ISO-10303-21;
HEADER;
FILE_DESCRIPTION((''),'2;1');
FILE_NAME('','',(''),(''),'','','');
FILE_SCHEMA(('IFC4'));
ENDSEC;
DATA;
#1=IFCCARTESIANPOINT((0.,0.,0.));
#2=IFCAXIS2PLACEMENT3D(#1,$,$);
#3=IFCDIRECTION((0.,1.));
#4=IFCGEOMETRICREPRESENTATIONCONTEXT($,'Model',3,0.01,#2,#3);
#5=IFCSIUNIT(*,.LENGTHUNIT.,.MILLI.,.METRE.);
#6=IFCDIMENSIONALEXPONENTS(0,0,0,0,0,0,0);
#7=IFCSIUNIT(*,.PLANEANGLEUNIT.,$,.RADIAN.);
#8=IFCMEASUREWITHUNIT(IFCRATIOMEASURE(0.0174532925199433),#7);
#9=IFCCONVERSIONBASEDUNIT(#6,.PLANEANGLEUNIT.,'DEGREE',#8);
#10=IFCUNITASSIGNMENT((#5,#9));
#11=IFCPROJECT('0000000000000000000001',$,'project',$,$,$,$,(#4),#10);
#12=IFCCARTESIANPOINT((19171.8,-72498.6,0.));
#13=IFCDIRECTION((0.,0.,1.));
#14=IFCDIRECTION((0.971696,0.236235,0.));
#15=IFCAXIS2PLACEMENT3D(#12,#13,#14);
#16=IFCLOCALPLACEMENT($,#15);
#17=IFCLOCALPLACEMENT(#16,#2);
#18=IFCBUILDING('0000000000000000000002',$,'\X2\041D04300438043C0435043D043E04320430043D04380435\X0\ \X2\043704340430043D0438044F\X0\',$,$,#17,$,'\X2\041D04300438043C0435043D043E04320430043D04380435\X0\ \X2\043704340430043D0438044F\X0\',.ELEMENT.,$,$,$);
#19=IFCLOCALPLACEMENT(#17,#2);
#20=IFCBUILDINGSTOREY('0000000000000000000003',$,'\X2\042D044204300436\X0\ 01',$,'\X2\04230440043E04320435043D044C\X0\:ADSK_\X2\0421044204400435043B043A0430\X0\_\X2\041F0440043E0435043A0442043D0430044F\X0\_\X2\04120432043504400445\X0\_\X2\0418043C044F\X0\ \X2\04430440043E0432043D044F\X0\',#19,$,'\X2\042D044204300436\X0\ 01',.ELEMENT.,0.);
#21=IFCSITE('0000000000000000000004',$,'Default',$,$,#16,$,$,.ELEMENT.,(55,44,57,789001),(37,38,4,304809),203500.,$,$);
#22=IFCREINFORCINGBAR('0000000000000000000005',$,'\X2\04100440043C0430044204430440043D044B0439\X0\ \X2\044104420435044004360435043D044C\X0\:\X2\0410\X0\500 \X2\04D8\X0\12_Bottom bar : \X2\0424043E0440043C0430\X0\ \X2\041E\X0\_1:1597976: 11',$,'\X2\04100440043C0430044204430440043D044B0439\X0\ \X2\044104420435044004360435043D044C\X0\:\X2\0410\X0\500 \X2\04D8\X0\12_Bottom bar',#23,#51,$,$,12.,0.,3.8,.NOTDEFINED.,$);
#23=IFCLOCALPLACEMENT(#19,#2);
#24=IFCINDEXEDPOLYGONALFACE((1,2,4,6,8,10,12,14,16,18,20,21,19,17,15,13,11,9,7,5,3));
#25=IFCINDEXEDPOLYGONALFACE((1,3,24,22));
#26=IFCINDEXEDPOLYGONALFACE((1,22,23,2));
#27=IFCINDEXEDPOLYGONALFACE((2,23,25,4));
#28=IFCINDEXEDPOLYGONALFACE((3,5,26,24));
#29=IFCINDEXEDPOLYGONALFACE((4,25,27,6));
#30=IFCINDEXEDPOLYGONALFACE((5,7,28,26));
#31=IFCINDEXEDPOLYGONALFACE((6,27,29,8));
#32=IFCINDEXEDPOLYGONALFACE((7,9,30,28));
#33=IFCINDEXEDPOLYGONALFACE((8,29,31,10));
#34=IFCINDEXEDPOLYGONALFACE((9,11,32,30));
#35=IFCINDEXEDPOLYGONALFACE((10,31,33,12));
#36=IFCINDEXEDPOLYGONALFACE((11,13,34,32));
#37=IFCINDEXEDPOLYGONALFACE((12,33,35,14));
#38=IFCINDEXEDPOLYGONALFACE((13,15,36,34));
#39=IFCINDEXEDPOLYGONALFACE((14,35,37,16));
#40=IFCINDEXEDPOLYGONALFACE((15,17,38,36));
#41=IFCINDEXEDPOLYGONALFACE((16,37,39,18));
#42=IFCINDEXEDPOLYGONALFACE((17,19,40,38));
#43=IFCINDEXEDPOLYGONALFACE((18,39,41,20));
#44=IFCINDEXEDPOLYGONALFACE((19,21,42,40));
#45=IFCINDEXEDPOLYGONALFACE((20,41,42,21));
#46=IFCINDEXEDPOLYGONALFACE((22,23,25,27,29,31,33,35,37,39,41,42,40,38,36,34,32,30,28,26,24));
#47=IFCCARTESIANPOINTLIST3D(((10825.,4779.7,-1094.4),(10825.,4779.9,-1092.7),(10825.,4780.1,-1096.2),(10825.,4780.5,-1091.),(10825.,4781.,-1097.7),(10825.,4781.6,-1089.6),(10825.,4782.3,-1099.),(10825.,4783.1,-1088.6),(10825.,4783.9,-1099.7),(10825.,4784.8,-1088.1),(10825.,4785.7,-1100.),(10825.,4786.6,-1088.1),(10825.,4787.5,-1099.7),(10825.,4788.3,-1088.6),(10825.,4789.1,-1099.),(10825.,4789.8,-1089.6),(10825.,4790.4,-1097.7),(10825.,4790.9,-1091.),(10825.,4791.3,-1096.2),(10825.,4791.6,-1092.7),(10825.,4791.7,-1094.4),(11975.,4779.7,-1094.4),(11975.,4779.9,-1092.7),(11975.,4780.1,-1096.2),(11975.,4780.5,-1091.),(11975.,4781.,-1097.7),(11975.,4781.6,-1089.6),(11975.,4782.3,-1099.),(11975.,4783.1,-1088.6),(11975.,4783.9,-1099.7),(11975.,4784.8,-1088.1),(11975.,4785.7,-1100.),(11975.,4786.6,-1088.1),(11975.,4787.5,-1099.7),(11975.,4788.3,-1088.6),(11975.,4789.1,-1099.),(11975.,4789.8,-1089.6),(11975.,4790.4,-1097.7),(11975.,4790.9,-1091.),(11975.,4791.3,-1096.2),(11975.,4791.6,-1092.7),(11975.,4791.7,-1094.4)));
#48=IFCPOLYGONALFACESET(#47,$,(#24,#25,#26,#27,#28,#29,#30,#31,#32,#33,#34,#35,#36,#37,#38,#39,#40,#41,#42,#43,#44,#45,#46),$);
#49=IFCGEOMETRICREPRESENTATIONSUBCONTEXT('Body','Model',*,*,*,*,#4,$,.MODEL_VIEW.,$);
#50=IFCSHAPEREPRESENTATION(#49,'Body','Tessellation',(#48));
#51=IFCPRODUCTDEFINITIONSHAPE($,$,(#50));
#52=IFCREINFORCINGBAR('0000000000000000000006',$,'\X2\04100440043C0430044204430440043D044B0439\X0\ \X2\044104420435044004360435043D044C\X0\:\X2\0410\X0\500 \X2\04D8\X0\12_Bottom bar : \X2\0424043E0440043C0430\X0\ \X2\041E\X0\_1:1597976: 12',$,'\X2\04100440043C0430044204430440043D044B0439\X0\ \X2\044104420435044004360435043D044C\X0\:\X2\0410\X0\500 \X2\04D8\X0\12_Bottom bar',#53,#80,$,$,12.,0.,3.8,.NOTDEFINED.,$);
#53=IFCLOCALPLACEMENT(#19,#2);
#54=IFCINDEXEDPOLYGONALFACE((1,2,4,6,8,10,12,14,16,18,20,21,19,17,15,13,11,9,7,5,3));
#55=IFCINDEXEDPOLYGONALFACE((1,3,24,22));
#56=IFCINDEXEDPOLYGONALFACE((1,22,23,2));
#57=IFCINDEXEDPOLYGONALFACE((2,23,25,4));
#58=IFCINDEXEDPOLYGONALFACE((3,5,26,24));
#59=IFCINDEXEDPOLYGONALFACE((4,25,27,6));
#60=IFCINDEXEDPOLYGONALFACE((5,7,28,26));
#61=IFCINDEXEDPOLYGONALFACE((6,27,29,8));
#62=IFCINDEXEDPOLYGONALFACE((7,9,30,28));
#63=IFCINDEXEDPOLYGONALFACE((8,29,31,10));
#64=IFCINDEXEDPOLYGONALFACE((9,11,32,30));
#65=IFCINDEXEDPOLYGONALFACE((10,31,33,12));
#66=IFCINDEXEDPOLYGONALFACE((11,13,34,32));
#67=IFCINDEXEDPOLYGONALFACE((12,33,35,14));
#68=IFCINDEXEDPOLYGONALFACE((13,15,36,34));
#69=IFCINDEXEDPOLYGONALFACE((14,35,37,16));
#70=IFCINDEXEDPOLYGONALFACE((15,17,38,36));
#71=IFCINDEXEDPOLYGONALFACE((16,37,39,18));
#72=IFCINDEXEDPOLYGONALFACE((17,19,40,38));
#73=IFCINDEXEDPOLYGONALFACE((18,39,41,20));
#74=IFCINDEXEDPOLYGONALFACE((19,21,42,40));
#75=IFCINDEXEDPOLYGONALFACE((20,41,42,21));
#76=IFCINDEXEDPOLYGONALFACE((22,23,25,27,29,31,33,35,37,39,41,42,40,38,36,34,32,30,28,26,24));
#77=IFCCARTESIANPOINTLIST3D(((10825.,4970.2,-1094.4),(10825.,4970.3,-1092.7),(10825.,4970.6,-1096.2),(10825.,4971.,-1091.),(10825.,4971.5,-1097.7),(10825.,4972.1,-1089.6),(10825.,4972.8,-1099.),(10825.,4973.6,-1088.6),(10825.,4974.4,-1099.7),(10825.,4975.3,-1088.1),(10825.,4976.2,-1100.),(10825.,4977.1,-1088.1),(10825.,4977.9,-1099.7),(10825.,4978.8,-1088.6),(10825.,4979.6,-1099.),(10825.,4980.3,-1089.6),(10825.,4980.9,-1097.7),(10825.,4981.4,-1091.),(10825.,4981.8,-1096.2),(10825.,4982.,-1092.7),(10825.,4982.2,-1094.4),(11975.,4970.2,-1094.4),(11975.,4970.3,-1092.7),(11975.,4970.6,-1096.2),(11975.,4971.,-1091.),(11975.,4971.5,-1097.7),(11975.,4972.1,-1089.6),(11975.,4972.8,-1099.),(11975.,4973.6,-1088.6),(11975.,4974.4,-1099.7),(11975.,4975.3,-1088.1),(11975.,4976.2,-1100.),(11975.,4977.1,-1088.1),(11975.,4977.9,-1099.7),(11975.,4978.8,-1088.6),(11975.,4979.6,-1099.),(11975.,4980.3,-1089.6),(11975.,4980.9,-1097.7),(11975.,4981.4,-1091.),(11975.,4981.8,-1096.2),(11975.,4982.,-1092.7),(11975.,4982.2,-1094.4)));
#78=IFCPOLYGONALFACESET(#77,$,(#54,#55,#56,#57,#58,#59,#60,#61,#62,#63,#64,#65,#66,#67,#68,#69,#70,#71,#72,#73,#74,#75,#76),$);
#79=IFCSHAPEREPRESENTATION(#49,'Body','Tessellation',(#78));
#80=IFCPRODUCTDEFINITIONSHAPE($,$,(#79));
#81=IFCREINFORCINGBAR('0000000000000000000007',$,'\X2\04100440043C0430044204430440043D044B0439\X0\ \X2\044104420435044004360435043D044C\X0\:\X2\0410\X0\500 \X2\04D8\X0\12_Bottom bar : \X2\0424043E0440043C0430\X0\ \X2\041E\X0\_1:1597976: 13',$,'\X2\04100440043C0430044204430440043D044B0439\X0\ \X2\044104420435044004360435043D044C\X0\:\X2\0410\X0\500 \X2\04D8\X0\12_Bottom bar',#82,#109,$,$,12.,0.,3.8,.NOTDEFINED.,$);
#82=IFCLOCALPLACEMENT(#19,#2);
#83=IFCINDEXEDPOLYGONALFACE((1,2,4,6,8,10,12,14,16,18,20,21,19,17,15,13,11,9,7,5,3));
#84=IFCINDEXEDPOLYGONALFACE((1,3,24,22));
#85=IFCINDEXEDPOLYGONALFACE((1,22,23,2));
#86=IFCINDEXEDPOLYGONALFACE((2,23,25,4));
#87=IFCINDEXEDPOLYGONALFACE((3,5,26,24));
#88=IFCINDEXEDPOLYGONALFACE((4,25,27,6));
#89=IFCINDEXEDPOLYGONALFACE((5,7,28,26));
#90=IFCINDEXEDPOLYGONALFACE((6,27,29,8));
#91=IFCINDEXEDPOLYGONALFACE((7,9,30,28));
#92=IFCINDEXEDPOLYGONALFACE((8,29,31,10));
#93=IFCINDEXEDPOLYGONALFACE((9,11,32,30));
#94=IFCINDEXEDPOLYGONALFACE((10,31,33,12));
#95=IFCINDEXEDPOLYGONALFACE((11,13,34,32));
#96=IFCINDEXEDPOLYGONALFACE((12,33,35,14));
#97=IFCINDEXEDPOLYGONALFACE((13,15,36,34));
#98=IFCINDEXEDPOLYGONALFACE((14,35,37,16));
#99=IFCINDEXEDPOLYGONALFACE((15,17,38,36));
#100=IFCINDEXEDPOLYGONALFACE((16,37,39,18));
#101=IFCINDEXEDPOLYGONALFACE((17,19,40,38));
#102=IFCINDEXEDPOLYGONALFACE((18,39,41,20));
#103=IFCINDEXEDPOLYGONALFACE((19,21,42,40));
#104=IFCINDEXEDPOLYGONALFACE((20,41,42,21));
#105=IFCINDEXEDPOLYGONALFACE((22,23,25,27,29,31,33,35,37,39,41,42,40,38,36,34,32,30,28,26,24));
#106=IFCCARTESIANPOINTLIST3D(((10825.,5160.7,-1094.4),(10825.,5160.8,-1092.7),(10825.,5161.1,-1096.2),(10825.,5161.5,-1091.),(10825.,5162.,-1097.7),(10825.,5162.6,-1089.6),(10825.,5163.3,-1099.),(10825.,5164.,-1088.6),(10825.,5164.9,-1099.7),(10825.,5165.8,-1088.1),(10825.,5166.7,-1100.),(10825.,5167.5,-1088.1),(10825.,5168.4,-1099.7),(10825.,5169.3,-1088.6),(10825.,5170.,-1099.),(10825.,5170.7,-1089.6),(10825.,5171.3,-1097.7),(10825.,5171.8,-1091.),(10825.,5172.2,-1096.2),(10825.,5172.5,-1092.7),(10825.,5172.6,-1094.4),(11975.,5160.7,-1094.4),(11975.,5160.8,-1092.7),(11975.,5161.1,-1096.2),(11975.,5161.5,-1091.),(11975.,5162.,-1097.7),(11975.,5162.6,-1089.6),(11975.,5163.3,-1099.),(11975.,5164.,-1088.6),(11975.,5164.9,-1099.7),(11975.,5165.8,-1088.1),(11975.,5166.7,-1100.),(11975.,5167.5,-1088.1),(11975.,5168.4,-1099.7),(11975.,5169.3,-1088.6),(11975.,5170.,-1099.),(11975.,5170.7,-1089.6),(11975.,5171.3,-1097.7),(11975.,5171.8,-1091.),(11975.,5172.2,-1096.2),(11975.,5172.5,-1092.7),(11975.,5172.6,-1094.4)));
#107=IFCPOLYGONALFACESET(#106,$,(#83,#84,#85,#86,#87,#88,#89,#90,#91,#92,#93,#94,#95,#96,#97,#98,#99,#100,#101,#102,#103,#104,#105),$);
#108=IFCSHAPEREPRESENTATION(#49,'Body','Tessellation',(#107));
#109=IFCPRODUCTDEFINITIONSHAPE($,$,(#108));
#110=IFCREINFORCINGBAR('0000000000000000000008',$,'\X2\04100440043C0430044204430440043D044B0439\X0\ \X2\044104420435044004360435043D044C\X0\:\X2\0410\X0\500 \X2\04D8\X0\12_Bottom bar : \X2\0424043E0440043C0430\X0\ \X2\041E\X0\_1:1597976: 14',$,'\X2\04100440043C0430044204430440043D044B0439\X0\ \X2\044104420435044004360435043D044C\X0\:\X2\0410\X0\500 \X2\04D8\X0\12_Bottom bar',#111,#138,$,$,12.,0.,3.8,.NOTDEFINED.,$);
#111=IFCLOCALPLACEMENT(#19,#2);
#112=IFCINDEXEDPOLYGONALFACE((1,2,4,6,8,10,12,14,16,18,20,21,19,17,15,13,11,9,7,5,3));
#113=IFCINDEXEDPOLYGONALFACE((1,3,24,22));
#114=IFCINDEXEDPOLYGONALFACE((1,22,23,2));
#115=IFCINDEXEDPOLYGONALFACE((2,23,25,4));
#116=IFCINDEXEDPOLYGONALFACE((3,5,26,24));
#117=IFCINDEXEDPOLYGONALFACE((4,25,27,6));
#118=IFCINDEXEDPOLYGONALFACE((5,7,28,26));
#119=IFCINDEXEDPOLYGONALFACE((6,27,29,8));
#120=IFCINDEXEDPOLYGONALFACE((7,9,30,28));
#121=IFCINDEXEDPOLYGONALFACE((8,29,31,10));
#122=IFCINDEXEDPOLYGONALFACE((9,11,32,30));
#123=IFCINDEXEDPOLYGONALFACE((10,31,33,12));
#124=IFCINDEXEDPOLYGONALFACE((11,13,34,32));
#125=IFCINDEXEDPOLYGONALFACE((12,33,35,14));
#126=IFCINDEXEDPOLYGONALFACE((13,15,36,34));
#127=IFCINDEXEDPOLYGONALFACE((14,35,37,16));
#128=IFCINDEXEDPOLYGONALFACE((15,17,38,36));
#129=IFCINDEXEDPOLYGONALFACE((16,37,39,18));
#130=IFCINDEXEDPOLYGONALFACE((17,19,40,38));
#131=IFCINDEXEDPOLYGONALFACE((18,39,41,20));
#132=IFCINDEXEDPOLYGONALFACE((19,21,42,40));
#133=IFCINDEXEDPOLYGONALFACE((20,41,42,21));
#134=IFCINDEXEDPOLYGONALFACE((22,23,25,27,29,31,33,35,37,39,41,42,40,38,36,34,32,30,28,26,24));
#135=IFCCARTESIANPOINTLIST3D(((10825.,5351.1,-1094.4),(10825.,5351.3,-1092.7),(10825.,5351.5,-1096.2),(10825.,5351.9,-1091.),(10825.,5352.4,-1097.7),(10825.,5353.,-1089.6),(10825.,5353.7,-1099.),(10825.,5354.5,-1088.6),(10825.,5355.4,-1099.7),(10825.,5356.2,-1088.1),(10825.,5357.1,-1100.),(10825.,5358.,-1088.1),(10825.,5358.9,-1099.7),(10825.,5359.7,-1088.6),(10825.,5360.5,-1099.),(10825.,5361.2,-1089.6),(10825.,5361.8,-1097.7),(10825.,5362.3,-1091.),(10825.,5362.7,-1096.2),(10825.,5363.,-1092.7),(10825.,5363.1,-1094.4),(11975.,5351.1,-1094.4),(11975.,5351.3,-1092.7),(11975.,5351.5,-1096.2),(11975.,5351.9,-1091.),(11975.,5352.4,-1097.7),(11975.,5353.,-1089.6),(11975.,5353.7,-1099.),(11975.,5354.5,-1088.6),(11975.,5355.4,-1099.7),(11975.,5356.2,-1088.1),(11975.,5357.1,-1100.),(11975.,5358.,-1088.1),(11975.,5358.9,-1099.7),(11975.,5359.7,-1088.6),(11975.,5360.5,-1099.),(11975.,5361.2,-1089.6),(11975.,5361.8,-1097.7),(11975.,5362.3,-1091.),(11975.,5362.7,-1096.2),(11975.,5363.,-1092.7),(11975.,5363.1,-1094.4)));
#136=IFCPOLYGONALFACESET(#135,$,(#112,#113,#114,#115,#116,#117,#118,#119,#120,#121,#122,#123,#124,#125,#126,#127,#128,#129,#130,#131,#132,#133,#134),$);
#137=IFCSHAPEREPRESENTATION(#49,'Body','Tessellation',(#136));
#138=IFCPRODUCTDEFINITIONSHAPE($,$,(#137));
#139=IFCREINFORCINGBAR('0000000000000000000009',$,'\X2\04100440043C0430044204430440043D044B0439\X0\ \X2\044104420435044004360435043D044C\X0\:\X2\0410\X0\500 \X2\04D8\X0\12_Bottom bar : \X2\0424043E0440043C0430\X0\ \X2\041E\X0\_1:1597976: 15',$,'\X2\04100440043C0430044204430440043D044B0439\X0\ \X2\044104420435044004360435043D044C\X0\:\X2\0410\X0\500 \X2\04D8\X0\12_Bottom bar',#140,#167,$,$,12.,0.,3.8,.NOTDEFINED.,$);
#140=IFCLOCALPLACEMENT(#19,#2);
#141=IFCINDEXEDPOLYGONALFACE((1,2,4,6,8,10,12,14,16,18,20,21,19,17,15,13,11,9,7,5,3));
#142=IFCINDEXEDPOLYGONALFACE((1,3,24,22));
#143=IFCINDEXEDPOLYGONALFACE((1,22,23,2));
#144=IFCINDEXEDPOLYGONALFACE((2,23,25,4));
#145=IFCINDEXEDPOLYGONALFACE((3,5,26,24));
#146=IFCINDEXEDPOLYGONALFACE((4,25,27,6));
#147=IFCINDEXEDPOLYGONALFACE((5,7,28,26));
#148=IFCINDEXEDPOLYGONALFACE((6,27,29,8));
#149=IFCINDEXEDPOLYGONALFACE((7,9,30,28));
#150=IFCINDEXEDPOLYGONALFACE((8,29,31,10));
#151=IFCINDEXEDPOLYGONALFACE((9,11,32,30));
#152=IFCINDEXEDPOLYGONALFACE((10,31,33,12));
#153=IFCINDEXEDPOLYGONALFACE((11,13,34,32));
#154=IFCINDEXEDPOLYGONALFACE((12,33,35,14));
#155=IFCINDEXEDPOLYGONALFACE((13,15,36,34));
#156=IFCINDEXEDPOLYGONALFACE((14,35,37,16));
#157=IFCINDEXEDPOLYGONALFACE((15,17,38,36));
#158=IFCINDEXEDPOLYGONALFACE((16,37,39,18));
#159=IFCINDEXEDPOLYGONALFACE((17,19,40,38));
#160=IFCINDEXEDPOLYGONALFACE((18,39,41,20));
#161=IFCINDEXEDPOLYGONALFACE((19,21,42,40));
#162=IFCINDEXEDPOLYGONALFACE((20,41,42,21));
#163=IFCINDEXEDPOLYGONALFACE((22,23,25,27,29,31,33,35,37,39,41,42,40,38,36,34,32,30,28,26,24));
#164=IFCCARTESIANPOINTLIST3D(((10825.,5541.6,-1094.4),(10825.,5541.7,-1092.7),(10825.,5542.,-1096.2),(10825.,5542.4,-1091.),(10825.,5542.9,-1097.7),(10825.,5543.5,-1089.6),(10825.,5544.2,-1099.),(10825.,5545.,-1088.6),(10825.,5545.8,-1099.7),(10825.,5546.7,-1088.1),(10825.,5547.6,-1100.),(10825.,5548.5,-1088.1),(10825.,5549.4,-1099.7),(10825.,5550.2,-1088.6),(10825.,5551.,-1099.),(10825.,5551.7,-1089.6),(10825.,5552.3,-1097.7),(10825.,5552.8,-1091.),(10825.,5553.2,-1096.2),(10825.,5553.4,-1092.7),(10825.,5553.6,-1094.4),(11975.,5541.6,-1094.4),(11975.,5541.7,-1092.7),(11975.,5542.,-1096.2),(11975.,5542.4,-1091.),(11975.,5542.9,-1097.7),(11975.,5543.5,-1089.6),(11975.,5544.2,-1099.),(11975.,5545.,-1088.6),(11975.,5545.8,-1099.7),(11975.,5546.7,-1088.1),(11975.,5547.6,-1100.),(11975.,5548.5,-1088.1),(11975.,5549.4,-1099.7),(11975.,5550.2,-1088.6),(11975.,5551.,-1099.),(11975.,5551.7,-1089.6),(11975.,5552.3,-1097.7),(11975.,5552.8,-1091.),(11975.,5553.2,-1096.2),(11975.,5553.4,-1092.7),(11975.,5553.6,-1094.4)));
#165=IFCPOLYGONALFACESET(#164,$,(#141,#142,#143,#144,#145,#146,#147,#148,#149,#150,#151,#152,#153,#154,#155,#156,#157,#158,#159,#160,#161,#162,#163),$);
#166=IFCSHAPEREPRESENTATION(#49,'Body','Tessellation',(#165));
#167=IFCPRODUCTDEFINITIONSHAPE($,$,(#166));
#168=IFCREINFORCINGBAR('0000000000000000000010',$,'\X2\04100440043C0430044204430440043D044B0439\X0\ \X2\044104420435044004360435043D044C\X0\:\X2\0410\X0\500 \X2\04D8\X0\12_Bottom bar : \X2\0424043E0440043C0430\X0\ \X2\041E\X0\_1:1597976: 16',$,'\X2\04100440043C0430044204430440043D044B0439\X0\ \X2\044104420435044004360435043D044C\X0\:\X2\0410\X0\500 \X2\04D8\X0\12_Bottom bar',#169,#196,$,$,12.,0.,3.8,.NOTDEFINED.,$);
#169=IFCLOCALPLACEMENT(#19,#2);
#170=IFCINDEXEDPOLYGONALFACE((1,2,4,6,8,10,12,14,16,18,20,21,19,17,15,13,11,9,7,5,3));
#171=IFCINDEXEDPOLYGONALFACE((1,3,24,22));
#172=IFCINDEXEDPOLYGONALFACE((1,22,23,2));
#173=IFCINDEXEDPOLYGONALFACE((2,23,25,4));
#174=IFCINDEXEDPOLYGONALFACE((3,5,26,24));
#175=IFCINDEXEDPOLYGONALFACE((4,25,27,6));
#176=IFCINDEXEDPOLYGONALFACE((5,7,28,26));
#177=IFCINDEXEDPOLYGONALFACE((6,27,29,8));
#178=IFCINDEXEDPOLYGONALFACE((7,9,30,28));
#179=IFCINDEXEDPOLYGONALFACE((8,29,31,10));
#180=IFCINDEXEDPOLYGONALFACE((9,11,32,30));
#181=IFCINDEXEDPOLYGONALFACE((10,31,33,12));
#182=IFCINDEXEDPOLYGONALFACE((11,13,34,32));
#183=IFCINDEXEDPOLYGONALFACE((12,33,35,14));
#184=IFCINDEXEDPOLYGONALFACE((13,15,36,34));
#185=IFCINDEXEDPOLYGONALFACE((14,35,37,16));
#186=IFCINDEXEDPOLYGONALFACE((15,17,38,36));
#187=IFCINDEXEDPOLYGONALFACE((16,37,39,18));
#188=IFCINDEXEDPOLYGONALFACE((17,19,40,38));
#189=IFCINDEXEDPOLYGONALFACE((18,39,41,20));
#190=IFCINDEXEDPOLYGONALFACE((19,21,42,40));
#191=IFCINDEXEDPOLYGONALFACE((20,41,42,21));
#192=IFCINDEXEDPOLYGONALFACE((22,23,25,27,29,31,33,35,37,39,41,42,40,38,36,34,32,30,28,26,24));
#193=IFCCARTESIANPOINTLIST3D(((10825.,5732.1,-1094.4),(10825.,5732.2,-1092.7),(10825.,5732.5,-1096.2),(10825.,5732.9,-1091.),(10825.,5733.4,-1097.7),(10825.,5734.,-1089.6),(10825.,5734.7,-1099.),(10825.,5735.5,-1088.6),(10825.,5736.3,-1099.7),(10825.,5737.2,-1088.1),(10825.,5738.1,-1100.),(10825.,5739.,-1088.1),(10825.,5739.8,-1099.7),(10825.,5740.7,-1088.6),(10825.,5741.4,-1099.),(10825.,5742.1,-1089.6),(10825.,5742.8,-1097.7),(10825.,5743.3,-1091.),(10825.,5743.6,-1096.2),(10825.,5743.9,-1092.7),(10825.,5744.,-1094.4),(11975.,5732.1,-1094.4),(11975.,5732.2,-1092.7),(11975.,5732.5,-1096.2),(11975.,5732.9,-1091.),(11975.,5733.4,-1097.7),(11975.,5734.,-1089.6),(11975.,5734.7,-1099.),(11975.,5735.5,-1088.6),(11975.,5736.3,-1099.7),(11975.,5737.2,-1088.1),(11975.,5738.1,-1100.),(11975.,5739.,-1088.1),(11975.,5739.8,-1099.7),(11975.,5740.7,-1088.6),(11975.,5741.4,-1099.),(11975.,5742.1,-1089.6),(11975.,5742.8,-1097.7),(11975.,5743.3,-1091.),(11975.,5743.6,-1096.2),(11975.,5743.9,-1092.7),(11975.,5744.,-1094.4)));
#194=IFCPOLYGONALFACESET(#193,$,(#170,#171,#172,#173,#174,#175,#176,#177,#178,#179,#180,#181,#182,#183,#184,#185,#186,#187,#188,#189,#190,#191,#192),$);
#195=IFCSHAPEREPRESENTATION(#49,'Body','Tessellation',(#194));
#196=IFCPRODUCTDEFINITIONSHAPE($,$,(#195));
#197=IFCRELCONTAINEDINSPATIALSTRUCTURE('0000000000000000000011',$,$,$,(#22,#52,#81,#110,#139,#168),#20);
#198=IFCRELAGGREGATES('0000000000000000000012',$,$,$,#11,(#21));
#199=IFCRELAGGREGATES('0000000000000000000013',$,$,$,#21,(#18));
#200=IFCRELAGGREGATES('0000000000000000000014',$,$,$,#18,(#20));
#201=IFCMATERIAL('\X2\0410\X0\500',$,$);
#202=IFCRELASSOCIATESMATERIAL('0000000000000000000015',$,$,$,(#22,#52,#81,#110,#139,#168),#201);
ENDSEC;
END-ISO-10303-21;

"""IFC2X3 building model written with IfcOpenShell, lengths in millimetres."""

from ifc_helpers import new_model, entity, si_unit, converted_unit, direction, frame, origin, place, context, subcontext, project, spatial, material, element, save


model = new_model("IFC2X3")

# Units and contexts
model_context = context("Model", 3, precision=0.01, world=origin(), true_north=direction((0.0, 1.0)))
body_context = subcontext(model_context, "Body", "Model", "MODEL_VIEW")
ifc_project = project(units=[si_unit("LENGTHUNIT", "METRE", prefix="MILLI"), converted_unit("PLANEANGLEUNIT", "DEGREE", entity("IfcRatioMeasure", 0.0174532925199433), si_unit("PLANEANGLEUNIT", "RADIAN"), dimensions=[0, 0, 0, 0, 0, 0, 0])], contexts=[model_context])

# Site, building, storey
site_placement = place(None, frame((19171.8, -72498.6, 0.0), z_axis=(0.0, 0.0, 1.0), x_axis=(0.971696, 0.236235, 0.0)))
site = spatial("IfcSite", under=ifc_project, at=site_placement, Name="Default", CompositionType="ELEMENT", RefLatitude=(55, 44, 57, 789001), RefLongitude=(37, 38, 4, 304809), RefElevation=203500.0)
building_placement = place(site_placement, origin())
building = spatial("IfcBuilding", under=site, at=building_placement, Name="Наименование здания", LongName="Наименование здания", CompositionType="ELEMENT")
storey_placement = place(building_placement, origin())
storey = spatial("IfcBuildingStorey", under=building, at=storey_placement, Name="Этаж 01", ObjectType="Уровень:ADSK_Стрелка_Проектная_Вверх_Имя уровня", LongName="Этаж 01", CompositionType="ELEMENT", Elevation=0.0)

# Reinforcing bars
ifc_material = material(Name="А500")
placement = place(storey_placement, origin())
element("IfcReinforcingBar", 1, at=placement, inside=storey, material=ifc_material, Name="Арматурный стержень:А500 Ә12_Bottom bar : Форма О_1:1597976: 11", ObjectType="Арматурный стержень:А500 Ә12_Bottom bar", BarLength=3.8, BarRole="NOTDEFINED", CrossSectionArea=0.0, NominalDiameter=12.0, context=body_context, shape_type="AdvancedSweptSolid", body=[
    entity("IfcSweptDiskSolid", entity("IfcCompositeCurve", [entity("IfcCompositeCurveSegment", "CONTINUOUS", True, entity("IfcPolyline", [entity("IfcCartesianPoint", [11975.0, 4785.7, -1094.0]), entity("IfcCartesianPoint", [10825.0, 4785.7, -1094.0])]))], False), 6.0, None, 0.0, 1.0),
])
element("IfcReinforcingBar", 2, at=placement, inside=storey, material=ifc_material, Name="Арматурный стержень:А500 Ә12_Bottom bar : Форма О_1:1597976: 12", ObjectType="Арматурный стержень:А500 Ә12_Bottom bar", BarLength=3.8, BarRole="NOTDEFINED", CrossSectionArea=0.0, NominalDiameter=12.0, context=body_context, shape_type="AdvancedSweptSolid", body=[
    entity("IfcSweptDiskSolid", entity("IfcCompositeCurve", [entity("IfcCompositeCurveSegment", "CONTINUOUS", True, entity("IfcPolyline", [entity("IfcCartesianPoint", [11975.0, 4976.2, -1094.0]), entity("IfcCartesianPoint", [10825.0, 4976.2, -1094.0])]))], False), 6.0, None, 0.0, 1.0),
])
element("IfcReinforcingBar", 3, at=placement, inside=storey, material=ifc_material, Name="Арматурный стержень:А500 Ә12_Bottom bar : Форма О_1:1597976: 13", ObjectType="Арматурный стержень:А500 Ә12_Bottom bar", BarLength=3.8, BarRole="NOTDEFINED", CrossSectionArea=0.0, NominalDiameter=12.0, context=body_context, shape_type="AdvancedSweptSolid", body=[
    entity("IfcSweptDiskSolid", entity("IfcCompositeCurve", [entity("IfcCompositeCurveSegment", "CONTINUOUS", True, entity("IfcPolyline", [entity("IfcCartesianPoint", [11975.0, 5166.6, -1094.0]), entity("IfcCartesianPoint", [10825.0, 5166.6, -1094.0])]))], False), 6.0, None, 0.0, 1.0),
])
element("IfcReinforcingBar", 4, at=placement, inside=storey, material=ifc_material, Name="Арматурный стержень:А500 Ә12_Bottom bar : Форма О_1:1597976: 14", ObjectType="Арматурный стержень:А500 Ә12_Bottom bar", BarLength=3.8, BarRole="NOTDEFINED", CrossSectionArea=0.0, NominalDiameter=12.0, context=body_context, shape_type="AdvancedSweptSolid", body=[
    entity("IfcSweptDiskSolid", entity("IfcCompositeCurve", [entity("IfcCompositeCurveSegment", "CONTINUOUS", True, entity("IfcPolyline", [entity("IfcCartesianPoint", [11975.0, 5357.1, -1094.0]), entity("IfcCartesianPoint", [10825.0, 5357.1, -1094.0])]))], False), 6.0, None, 0.0, 1.0),
])
element("IfcReinforcingBar", 5, at=placement, inside=storey, material=ifc_material, Name="Арматурный стержень:А500 Ә12_Bottom bar : Форма О_1:1597976: 15", ObjectType="Арматурный стержень:А500 Ә12_Bottom bar", BarLength=3.8, BarRole="NOTDEFINED", CrossSectionArea=0.0, NominalDiameter=12.0, context=body_context, shape_type="AdvancedSweptSolid", body=[
    entity("IfcSweptDiskSolid", entity("IfcCompositeCurve", [entity("IfcCompositeCurveSegment", "CONTINUOUS", True, entity("IfcPolyline", [entity("IfcCartesianPoint", [11975.0, 5547.6, -1094.0]), entity("IfcCartesianPoint", [10825.0, 5547.6, -1094.0])]))], False), 6.0, None, 0.0, 1.0),
])
element("IfcReinforcingBar", 6, at=placement, inside=storey, material=ifc_material, Name="Арматурный стержень:А500 Ә12_Bottom bar : Форма О_1:1597976: 16", ObjectType="Арматурный стержень:А500 Ә12_Bottom bar", BarLength=3.8, BarRole="NOTDEFINED", CrossSectionArea=0.0, NominalDiameter=12.0, context=body_context, shape_type="AdvancedSweptSolid", body=[
    entity("IfcSweptDiskSolid", entity("IfcCompositeCurve", [entity("IfcCompositeCurveSegment", "CONTINUOUS", True, entity("IfcPolyline", [entity("IfcCartesianPoint", [11975.0, 5738.1, -1094.0]), entity("IfcCartesianPoint", [10825.0, 5738.1, -1094.0])]))], False), 6.0, None, 0.0, 1.0),
])

save(model, "model.ifc")
